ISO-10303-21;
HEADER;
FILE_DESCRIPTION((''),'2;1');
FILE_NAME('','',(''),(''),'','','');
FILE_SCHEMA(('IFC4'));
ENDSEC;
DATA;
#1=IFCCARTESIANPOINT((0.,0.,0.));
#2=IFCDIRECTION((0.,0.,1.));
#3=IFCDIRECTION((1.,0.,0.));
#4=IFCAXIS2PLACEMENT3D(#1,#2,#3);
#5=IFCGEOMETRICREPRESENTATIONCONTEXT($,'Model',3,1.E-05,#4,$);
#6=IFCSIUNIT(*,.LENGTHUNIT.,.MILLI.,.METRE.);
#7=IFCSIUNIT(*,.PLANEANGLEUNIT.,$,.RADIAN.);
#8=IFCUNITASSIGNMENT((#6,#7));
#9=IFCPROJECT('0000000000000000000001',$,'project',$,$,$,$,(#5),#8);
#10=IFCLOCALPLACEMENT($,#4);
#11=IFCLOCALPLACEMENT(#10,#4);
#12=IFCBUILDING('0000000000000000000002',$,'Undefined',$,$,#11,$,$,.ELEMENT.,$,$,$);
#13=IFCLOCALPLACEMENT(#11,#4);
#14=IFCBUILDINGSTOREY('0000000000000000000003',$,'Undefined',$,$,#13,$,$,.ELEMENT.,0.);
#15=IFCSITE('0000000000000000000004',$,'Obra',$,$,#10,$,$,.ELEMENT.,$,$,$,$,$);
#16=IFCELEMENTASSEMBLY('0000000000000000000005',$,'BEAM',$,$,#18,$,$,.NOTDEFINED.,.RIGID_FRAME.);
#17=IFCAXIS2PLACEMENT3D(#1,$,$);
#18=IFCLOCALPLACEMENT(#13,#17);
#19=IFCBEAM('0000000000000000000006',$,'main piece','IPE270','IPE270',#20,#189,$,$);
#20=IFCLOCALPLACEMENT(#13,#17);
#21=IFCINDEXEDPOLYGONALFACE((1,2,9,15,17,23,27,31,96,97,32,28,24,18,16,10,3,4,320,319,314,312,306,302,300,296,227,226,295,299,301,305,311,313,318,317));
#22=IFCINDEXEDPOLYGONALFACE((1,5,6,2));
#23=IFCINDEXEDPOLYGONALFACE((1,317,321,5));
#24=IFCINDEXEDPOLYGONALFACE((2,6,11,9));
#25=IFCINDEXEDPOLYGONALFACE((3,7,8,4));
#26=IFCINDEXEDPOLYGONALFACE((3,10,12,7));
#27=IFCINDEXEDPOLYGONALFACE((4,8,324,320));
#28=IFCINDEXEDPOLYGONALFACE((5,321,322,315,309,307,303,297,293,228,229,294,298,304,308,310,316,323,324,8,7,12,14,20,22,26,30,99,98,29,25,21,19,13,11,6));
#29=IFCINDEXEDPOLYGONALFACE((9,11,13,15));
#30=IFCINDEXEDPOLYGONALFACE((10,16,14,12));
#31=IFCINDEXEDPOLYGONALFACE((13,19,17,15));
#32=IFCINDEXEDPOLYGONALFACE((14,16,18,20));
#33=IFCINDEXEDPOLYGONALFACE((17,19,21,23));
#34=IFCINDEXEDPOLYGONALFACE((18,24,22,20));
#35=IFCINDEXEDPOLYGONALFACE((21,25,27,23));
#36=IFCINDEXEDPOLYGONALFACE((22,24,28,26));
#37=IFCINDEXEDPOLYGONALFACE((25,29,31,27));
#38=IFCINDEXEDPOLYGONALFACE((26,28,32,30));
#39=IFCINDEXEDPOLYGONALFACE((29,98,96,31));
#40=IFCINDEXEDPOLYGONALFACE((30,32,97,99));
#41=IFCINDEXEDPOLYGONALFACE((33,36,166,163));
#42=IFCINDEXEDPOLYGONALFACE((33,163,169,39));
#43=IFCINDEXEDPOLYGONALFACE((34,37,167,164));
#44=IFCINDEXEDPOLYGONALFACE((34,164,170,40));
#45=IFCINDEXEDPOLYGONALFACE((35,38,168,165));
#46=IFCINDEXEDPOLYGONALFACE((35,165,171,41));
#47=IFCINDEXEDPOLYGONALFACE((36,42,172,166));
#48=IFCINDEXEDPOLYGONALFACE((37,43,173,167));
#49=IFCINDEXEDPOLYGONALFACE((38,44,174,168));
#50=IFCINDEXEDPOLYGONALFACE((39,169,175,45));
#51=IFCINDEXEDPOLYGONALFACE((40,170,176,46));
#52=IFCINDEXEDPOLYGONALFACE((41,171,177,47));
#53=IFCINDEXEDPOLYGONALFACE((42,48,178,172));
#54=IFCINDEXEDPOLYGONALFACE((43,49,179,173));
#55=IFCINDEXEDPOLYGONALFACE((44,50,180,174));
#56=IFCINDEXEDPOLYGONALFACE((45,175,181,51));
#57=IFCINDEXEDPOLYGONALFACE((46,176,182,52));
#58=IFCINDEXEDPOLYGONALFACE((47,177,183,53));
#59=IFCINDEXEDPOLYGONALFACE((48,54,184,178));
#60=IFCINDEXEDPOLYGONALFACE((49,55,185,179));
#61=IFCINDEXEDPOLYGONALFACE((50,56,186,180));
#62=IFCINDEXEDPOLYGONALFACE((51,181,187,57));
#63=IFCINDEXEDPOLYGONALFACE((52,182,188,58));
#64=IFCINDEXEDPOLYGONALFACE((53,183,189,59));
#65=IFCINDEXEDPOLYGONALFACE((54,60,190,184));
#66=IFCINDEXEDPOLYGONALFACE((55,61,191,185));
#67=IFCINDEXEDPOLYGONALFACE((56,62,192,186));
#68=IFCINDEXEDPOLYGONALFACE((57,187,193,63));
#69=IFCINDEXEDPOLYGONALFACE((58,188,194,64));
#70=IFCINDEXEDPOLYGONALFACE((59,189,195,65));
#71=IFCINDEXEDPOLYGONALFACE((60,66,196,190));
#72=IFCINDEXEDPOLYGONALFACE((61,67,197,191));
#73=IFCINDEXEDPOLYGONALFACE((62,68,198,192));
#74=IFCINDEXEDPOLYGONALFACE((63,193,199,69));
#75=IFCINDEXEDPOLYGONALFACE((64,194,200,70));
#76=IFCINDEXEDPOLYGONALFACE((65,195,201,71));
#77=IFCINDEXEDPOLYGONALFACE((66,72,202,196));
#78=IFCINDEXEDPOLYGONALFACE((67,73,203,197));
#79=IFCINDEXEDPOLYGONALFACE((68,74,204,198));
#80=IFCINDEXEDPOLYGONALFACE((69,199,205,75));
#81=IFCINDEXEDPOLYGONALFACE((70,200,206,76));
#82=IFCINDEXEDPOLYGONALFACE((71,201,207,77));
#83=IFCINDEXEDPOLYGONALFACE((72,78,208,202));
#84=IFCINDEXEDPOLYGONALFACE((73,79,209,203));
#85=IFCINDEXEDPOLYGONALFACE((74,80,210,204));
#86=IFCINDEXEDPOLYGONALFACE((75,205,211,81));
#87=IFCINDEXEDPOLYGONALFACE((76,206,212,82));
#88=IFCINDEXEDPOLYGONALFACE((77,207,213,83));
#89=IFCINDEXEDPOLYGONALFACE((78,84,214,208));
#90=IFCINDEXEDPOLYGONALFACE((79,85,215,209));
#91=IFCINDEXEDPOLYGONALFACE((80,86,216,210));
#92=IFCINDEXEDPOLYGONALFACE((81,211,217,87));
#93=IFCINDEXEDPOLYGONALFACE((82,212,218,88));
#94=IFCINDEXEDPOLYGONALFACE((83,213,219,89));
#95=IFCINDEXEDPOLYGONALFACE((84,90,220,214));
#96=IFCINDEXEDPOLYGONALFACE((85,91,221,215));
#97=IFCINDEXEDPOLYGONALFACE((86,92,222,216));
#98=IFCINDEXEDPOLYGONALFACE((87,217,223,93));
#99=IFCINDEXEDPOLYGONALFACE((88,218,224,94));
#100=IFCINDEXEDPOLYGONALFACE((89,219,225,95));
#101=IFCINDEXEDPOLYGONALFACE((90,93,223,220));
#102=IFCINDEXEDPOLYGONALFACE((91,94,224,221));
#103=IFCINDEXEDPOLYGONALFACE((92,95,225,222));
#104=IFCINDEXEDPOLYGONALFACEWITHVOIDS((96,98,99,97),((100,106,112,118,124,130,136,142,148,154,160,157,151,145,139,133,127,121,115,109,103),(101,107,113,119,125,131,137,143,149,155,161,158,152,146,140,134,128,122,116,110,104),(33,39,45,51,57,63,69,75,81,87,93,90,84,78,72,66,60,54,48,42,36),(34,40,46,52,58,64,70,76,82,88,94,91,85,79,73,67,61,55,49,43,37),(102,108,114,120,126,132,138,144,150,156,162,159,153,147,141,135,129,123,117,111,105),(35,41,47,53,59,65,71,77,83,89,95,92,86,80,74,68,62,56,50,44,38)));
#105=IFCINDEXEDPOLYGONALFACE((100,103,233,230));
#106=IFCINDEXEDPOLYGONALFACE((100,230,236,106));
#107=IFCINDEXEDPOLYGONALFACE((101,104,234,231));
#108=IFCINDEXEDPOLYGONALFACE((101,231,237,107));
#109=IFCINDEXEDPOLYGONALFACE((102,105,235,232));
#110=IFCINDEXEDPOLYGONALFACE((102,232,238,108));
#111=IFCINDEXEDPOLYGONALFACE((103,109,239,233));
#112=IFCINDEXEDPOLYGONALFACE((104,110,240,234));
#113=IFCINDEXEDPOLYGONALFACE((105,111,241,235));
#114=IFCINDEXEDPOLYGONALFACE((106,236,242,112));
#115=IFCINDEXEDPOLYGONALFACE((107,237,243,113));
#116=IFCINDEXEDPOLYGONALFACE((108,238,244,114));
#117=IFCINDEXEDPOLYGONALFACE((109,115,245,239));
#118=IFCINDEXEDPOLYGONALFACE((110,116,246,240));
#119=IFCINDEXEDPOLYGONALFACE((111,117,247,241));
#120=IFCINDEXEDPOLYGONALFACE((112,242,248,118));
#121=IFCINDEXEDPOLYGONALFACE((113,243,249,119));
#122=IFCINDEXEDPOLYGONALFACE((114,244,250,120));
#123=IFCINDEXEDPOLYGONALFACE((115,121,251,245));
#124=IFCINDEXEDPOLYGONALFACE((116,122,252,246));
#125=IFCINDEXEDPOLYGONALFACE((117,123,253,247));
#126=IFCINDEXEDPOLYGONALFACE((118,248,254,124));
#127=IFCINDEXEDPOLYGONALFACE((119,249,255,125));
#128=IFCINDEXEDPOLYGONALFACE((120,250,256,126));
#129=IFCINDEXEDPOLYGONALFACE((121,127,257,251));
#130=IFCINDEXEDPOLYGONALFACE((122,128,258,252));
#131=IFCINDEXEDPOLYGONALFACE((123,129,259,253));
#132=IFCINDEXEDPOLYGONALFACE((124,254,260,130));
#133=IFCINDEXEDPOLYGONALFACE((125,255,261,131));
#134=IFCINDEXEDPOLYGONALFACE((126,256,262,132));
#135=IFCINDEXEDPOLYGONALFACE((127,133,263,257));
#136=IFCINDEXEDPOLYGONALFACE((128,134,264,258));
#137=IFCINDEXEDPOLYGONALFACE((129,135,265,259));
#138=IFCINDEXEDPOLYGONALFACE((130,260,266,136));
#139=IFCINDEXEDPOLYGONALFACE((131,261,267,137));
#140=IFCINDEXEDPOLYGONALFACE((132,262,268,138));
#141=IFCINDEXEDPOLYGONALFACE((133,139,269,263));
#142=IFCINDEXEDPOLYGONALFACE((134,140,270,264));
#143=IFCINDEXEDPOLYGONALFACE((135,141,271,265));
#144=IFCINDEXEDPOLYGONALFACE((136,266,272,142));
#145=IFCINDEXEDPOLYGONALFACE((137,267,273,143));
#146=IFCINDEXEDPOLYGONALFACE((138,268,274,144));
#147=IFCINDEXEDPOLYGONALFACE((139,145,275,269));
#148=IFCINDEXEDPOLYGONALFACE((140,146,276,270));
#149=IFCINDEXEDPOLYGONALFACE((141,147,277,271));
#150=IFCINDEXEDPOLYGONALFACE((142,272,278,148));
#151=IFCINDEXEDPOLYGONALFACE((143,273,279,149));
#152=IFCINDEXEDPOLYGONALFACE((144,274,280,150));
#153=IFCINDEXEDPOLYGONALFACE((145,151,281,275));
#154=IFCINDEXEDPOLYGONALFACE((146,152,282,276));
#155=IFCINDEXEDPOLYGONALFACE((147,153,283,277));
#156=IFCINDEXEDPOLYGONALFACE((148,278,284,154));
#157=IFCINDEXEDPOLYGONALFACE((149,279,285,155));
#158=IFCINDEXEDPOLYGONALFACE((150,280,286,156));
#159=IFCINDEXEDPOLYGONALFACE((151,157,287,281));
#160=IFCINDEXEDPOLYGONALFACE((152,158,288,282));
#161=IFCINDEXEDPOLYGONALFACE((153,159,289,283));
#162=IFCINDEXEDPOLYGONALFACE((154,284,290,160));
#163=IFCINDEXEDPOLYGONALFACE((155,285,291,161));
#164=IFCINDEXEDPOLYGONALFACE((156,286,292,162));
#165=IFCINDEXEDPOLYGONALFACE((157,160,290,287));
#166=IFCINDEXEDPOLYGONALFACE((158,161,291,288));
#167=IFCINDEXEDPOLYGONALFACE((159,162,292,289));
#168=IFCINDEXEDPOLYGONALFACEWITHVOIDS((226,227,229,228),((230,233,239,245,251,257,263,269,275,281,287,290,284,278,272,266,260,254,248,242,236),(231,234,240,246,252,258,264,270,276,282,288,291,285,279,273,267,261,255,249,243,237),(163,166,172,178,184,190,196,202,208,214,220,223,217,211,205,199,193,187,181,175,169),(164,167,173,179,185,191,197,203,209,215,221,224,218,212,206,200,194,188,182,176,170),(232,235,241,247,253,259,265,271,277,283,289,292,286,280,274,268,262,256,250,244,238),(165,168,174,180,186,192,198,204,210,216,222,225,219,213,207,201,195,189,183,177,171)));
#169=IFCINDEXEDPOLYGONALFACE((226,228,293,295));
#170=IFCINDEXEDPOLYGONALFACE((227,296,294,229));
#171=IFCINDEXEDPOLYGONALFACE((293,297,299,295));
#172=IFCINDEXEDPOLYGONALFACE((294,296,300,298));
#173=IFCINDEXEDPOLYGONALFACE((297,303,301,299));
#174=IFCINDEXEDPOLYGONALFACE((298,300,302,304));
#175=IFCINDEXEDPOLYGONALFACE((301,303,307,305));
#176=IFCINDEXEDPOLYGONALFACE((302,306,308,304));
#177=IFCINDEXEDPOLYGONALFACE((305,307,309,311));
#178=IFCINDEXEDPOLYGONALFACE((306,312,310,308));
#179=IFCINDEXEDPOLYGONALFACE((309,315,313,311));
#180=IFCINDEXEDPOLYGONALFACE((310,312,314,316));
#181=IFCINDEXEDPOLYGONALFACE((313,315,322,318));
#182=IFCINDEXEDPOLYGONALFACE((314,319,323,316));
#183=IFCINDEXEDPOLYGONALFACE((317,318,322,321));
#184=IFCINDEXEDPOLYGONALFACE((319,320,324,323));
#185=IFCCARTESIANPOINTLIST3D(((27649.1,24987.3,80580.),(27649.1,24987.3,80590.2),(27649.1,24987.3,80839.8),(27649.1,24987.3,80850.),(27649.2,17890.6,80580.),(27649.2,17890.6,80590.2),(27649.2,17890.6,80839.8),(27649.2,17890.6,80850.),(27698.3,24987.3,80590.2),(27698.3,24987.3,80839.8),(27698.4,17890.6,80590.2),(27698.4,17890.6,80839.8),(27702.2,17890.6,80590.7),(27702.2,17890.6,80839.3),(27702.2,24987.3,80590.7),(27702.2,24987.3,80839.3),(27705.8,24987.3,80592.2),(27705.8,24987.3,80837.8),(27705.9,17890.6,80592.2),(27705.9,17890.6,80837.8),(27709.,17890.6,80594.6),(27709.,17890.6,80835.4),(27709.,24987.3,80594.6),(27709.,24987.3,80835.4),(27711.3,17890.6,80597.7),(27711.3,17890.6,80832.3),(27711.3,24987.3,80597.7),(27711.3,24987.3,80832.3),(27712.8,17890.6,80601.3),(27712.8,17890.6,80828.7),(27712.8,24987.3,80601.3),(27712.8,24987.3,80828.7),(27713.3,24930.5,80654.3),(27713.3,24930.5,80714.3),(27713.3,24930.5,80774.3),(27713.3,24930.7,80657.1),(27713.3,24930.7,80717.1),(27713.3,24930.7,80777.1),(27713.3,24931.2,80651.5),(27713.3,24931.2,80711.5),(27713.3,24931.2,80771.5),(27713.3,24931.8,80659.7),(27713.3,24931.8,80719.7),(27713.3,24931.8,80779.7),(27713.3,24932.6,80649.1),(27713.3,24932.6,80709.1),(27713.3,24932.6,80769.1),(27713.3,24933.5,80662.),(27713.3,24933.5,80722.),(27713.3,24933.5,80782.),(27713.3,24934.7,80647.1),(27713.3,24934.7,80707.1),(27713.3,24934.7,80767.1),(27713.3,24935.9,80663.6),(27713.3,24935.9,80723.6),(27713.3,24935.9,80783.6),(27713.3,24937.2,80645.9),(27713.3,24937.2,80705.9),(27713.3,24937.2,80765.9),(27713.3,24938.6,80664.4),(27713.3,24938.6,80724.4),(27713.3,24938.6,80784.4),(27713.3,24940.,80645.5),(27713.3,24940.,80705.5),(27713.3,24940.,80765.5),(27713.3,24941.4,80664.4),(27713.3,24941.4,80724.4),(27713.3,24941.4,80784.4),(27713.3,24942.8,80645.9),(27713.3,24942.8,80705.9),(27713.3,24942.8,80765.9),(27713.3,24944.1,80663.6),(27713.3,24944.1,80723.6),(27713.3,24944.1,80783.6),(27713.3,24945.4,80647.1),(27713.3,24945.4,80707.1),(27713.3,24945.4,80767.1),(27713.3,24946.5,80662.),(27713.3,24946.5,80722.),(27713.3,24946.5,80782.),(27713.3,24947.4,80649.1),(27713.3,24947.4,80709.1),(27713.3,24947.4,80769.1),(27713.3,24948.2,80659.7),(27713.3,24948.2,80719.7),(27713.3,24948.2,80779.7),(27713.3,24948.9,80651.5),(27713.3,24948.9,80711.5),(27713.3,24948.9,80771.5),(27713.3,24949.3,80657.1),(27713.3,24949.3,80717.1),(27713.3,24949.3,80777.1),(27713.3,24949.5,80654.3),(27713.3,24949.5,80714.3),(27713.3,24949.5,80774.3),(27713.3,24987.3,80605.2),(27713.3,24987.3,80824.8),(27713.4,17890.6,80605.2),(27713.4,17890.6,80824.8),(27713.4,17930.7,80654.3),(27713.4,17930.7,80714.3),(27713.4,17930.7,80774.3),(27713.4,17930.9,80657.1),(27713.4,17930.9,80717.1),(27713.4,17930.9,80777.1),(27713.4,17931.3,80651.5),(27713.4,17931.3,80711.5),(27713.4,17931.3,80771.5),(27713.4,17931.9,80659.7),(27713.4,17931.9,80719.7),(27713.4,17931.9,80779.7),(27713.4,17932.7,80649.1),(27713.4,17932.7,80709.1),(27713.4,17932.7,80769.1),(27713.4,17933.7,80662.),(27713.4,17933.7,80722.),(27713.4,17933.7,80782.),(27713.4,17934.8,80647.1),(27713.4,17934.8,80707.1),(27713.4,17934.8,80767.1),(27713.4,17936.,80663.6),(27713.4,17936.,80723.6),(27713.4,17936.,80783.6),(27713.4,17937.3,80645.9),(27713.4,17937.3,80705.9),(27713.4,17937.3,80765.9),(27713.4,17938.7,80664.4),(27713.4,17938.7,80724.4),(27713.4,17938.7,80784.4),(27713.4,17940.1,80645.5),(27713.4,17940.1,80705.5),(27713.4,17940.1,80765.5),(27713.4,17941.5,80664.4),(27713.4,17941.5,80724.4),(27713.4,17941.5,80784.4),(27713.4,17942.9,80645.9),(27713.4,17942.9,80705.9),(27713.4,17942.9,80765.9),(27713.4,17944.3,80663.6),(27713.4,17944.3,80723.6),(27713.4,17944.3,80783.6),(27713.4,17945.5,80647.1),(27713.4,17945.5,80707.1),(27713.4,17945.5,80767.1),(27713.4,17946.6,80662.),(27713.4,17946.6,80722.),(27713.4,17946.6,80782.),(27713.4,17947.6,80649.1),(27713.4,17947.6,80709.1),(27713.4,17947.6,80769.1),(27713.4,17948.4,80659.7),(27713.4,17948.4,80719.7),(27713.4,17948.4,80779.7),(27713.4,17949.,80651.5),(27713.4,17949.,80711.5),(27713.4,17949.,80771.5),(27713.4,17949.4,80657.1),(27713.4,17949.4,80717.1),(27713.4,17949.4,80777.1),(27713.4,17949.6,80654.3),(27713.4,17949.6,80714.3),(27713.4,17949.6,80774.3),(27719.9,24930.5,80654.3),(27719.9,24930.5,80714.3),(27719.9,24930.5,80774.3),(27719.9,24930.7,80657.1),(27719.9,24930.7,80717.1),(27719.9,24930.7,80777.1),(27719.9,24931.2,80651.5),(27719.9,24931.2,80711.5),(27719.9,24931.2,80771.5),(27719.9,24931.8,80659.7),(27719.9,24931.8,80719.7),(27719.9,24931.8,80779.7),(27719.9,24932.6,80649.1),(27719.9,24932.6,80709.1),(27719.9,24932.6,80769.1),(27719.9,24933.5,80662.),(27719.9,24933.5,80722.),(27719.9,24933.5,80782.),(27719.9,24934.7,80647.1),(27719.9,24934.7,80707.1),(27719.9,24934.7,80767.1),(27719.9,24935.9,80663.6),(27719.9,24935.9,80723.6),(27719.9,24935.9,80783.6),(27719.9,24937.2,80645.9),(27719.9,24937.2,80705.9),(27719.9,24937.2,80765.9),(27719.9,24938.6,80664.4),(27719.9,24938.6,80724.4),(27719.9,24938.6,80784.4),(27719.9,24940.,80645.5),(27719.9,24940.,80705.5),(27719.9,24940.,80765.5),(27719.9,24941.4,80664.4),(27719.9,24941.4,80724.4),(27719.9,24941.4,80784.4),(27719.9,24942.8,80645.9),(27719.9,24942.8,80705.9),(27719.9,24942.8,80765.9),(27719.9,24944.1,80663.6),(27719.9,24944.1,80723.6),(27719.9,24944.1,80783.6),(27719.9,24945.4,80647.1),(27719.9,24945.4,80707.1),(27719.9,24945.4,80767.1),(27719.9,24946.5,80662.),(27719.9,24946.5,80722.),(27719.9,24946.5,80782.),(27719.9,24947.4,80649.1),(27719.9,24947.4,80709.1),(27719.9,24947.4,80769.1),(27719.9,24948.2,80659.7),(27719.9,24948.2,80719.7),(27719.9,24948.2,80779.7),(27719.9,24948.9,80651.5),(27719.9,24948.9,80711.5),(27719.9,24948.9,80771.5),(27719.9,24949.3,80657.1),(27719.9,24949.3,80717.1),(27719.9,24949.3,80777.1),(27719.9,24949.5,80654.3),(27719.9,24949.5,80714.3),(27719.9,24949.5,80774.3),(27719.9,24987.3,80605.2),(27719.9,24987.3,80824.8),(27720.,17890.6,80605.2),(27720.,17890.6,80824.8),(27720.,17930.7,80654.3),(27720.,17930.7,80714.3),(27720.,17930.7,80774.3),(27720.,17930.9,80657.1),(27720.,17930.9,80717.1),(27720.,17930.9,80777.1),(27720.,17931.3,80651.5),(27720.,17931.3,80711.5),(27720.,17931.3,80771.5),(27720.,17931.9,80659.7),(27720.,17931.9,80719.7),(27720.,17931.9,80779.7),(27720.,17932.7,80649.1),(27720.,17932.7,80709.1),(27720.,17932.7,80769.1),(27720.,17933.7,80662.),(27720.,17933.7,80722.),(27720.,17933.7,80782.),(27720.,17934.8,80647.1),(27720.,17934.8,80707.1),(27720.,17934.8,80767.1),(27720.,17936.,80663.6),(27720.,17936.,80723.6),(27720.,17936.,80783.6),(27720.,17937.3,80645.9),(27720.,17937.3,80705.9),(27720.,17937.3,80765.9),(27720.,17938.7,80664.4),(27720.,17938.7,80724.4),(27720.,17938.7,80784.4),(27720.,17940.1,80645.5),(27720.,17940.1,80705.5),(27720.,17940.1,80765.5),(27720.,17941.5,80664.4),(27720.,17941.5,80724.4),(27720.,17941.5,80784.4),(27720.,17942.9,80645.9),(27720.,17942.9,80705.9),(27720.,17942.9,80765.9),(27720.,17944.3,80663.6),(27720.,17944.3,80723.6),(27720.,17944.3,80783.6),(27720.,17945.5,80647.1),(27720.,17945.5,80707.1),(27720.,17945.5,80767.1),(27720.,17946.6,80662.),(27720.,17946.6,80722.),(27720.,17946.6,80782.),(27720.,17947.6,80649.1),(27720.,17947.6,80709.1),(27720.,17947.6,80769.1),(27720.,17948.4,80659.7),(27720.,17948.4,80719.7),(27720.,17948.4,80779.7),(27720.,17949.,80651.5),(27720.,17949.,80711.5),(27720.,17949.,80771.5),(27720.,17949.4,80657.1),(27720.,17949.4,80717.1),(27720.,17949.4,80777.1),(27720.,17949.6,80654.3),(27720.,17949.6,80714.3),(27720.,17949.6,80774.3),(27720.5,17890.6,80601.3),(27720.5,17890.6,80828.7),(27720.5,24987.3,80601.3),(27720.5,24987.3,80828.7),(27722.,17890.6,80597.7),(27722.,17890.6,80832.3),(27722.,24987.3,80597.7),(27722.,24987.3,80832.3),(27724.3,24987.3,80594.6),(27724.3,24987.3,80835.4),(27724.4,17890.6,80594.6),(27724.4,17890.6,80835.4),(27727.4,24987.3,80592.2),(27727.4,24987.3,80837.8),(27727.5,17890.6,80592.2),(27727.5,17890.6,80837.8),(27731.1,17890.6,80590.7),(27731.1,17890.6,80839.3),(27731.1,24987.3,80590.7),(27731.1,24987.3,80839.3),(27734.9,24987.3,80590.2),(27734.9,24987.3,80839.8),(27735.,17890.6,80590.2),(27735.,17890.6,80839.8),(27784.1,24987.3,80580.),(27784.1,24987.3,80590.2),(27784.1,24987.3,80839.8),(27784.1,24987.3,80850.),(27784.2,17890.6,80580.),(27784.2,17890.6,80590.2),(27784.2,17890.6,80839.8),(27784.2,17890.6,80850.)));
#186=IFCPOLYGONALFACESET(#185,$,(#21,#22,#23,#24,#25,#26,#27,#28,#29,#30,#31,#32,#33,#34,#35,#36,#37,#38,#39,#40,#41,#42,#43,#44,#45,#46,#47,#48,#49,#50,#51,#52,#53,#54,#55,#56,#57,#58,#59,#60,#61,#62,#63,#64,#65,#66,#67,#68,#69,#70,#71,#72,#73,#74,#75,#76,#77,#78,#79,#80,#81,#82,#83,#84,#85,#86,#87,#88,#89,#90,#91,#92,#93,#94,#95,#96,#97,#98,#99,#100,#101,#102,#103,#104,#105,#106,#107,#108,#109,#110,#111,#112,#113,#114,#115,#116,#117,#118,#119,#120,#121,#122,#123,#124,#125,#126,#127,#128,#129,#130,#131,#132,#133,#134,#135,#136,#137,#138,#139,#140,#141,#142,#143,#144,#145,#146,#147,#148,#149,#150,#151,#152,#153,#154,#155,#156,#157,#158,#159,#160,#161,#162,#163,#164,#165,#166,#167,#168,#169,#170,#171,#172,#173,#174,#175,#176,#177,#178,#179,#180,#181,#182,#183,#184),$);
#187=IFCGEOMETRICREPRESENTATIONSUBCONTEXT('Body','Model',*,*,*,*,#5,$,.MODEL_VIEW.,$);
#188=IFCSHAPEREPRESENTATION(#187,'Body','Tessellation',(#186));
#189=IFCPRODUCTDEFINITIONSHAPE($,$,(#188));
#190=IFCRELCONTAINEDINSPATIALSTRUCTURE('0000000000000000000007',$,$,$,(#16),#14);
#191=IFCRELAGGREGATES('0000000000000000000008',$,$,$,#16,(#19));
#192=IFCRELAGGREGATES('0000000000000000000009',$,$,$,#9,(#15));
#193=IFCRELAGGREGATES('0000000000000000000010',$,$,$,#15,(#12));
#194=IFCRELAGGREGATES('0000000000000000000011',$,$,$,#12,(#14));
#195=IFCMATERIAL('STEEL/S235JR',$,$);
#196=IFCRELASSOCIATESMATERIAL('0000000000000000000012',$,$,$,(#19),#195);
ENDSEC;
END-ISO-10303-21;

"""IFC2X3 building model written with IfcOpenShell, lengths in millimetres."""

from ifc_helpers import new_model, si_unit, frame, origin_with_axes, origin_2d_with_axis, place, context, subcontext, project, spatial, circle, i_section, extrude, clip, halfspace, source, transform, mapped, material, element, aggregate, save


model = new_model("IFC2X3")

# Units and contexts
model_context = context("Model", 3, precision=1e-05, world=origin_with_axes())
body_context = subcontext(model_context, "Body", "Model", "MODEL_VIEW")
ifc_project = project(units=[si_unit("LENGTHUNIT", "METRE", prefix="MILLI"), si_unit("PLANEANGLEUNIT", "RADIAN")], contexts=[model_context])

# Site, building, storey
site_placement = place(None, origin_with_axes())
site = spatial("IfcSite", under=ifc_project, at=site_placement, Name="Obra", CompositionType="ELEMENT")
building_placement = place(site_placement, origin_with_axes())
building = spatial("IfcBuilding", under=site, at=building_placement, Name="Undefined", CompositionType="ELEMENT")
storey_placement = place(building_placement, origin_with_axes())
storey = spatial("IfcBuildingStorey", under=building, at=storey_placement, Name="Undefined", CompositionType="ELEMENT", Elevation=0.0)

# Shared definitions
ifc_material = material(Name="STEEL/S235JR")

# Element assembly, beam, openings
assembly_1_placement = place(storey_placement, origin_with_axes())
assembly_1 = element("IfcElementAssembly", 1, at=assembly_1_placement, inside=storey, Name="BEAM", AssemblyPlace="NOTDEFINED", PredefinedType="RIGID_FRAME")
beam_1_placement = place(assembly_1_placement, frame((27716.7, 17630.1, 80715.0), z_axis=(0.0, 0.0, 1.0), x_axis=(-0.000001, 1.0, 0.0)))
beam_1 = element("IfcBeam", 2, at=beam_1_placement, material=ifc_material, Name="main piece", Description="IPE270", ObjectType="IPE270", context=body_context, shape_type="Clipping", body=[
    clip(clip(extrude(i_section(OverallWidth=135.0, OverallDepth=270.0, WebThickness=6.6, FlangeThickness=10.2, FilletRadius=15.0, at=origin_2d_with_axis()), frame((7357.1, 0.0, 0.0), z_axis=(-1.0, 0.0, 0.0), x_axis=(0.0, -1.0, 0.0)), (0.0, 0.0, 1.0), 7357.1), halfspace(frame((260.5, 60.0, -120.0), z_axis=(-1.0, -0.000017, 0.0), x_axis=(0.0, 0.0, 1.0)), False)), halfspace(frame((7359.4, -60.0, -120.0), z_axis=(1.0, 0.000019, 0.0), x_axis=(0.0, 0.0, 1.0)), False)),
])
shared_shape_1 = source(origin_with_axes(), body_context, "Body", "SweptSolid", [
    extrude(circle(Radius=9.5, at=origin_2d_with_axis()), frame((0.0, -3.4, 0.0), z_axis=(0.0, 1.0, 0.0), x_axis=(1.0, 0.0, 0.0)), (0.0, 0.0, 1.0), 6.8),
])
opening_1_placement = place(assembly_1_placement, frame((27716.7, 17890.1, 80835.0), z_axis=(0.0, 1.0, 0.0), x_axis=(0.0, 0.0, -1.0)))
element("IfcOpeningElement", 3, at=opening_1_placement, cuts=beam_1, ObjectType="Opening", context=body_context, shape_type="MappedRepresentation", body=[
    mapped(shared_shape_1, transform((60.0, 0.0, 50.0))),
    mapped(shared_shape_1, transform((120.0, 0.0, 50.0))),
    mapped(shared_shape_1, transform((180.0, 0.0, 50.0))),
])
shared_shape_2 = source(origin_with_axes(), body_context, "Body", "SweptSolid", [
    extrude(circle(Radius=9.5, at=origin_2d_with_axis()), frame((0.0, -3.4, 0.0), z_axis=(0.0, 1.0, 0.0), x_axis=(1.0, 0.0, 0.0)), (0.0, 0.0, 1.0), 6.8),
])
opening_2_placement = place(assembly_1_placement, frame((27716.6, 24990.0, 80835.0), z_axis=(0.000001, -1.0, 0.0), x_axis=(0.0, 0.0, -1.0)))
element("IfcOpeningElement", 4, at=opening_2_placement, cuts=beam_1, ObjectType="Opening", context=body_context, shape_type="MappedRepresentation", body=[
    mapped(shared_shape_2, transform((60.0, 0.0, 50.0))),
    mapped(shared_shape_2, transform((120.0, 0.0, 50.0))),
    mapped(shared_shape_2, transform((180.0, 0.0, 50.0))),
])
aggregate(assembly_1, [beam_1])

save(model, "model.ifc")
